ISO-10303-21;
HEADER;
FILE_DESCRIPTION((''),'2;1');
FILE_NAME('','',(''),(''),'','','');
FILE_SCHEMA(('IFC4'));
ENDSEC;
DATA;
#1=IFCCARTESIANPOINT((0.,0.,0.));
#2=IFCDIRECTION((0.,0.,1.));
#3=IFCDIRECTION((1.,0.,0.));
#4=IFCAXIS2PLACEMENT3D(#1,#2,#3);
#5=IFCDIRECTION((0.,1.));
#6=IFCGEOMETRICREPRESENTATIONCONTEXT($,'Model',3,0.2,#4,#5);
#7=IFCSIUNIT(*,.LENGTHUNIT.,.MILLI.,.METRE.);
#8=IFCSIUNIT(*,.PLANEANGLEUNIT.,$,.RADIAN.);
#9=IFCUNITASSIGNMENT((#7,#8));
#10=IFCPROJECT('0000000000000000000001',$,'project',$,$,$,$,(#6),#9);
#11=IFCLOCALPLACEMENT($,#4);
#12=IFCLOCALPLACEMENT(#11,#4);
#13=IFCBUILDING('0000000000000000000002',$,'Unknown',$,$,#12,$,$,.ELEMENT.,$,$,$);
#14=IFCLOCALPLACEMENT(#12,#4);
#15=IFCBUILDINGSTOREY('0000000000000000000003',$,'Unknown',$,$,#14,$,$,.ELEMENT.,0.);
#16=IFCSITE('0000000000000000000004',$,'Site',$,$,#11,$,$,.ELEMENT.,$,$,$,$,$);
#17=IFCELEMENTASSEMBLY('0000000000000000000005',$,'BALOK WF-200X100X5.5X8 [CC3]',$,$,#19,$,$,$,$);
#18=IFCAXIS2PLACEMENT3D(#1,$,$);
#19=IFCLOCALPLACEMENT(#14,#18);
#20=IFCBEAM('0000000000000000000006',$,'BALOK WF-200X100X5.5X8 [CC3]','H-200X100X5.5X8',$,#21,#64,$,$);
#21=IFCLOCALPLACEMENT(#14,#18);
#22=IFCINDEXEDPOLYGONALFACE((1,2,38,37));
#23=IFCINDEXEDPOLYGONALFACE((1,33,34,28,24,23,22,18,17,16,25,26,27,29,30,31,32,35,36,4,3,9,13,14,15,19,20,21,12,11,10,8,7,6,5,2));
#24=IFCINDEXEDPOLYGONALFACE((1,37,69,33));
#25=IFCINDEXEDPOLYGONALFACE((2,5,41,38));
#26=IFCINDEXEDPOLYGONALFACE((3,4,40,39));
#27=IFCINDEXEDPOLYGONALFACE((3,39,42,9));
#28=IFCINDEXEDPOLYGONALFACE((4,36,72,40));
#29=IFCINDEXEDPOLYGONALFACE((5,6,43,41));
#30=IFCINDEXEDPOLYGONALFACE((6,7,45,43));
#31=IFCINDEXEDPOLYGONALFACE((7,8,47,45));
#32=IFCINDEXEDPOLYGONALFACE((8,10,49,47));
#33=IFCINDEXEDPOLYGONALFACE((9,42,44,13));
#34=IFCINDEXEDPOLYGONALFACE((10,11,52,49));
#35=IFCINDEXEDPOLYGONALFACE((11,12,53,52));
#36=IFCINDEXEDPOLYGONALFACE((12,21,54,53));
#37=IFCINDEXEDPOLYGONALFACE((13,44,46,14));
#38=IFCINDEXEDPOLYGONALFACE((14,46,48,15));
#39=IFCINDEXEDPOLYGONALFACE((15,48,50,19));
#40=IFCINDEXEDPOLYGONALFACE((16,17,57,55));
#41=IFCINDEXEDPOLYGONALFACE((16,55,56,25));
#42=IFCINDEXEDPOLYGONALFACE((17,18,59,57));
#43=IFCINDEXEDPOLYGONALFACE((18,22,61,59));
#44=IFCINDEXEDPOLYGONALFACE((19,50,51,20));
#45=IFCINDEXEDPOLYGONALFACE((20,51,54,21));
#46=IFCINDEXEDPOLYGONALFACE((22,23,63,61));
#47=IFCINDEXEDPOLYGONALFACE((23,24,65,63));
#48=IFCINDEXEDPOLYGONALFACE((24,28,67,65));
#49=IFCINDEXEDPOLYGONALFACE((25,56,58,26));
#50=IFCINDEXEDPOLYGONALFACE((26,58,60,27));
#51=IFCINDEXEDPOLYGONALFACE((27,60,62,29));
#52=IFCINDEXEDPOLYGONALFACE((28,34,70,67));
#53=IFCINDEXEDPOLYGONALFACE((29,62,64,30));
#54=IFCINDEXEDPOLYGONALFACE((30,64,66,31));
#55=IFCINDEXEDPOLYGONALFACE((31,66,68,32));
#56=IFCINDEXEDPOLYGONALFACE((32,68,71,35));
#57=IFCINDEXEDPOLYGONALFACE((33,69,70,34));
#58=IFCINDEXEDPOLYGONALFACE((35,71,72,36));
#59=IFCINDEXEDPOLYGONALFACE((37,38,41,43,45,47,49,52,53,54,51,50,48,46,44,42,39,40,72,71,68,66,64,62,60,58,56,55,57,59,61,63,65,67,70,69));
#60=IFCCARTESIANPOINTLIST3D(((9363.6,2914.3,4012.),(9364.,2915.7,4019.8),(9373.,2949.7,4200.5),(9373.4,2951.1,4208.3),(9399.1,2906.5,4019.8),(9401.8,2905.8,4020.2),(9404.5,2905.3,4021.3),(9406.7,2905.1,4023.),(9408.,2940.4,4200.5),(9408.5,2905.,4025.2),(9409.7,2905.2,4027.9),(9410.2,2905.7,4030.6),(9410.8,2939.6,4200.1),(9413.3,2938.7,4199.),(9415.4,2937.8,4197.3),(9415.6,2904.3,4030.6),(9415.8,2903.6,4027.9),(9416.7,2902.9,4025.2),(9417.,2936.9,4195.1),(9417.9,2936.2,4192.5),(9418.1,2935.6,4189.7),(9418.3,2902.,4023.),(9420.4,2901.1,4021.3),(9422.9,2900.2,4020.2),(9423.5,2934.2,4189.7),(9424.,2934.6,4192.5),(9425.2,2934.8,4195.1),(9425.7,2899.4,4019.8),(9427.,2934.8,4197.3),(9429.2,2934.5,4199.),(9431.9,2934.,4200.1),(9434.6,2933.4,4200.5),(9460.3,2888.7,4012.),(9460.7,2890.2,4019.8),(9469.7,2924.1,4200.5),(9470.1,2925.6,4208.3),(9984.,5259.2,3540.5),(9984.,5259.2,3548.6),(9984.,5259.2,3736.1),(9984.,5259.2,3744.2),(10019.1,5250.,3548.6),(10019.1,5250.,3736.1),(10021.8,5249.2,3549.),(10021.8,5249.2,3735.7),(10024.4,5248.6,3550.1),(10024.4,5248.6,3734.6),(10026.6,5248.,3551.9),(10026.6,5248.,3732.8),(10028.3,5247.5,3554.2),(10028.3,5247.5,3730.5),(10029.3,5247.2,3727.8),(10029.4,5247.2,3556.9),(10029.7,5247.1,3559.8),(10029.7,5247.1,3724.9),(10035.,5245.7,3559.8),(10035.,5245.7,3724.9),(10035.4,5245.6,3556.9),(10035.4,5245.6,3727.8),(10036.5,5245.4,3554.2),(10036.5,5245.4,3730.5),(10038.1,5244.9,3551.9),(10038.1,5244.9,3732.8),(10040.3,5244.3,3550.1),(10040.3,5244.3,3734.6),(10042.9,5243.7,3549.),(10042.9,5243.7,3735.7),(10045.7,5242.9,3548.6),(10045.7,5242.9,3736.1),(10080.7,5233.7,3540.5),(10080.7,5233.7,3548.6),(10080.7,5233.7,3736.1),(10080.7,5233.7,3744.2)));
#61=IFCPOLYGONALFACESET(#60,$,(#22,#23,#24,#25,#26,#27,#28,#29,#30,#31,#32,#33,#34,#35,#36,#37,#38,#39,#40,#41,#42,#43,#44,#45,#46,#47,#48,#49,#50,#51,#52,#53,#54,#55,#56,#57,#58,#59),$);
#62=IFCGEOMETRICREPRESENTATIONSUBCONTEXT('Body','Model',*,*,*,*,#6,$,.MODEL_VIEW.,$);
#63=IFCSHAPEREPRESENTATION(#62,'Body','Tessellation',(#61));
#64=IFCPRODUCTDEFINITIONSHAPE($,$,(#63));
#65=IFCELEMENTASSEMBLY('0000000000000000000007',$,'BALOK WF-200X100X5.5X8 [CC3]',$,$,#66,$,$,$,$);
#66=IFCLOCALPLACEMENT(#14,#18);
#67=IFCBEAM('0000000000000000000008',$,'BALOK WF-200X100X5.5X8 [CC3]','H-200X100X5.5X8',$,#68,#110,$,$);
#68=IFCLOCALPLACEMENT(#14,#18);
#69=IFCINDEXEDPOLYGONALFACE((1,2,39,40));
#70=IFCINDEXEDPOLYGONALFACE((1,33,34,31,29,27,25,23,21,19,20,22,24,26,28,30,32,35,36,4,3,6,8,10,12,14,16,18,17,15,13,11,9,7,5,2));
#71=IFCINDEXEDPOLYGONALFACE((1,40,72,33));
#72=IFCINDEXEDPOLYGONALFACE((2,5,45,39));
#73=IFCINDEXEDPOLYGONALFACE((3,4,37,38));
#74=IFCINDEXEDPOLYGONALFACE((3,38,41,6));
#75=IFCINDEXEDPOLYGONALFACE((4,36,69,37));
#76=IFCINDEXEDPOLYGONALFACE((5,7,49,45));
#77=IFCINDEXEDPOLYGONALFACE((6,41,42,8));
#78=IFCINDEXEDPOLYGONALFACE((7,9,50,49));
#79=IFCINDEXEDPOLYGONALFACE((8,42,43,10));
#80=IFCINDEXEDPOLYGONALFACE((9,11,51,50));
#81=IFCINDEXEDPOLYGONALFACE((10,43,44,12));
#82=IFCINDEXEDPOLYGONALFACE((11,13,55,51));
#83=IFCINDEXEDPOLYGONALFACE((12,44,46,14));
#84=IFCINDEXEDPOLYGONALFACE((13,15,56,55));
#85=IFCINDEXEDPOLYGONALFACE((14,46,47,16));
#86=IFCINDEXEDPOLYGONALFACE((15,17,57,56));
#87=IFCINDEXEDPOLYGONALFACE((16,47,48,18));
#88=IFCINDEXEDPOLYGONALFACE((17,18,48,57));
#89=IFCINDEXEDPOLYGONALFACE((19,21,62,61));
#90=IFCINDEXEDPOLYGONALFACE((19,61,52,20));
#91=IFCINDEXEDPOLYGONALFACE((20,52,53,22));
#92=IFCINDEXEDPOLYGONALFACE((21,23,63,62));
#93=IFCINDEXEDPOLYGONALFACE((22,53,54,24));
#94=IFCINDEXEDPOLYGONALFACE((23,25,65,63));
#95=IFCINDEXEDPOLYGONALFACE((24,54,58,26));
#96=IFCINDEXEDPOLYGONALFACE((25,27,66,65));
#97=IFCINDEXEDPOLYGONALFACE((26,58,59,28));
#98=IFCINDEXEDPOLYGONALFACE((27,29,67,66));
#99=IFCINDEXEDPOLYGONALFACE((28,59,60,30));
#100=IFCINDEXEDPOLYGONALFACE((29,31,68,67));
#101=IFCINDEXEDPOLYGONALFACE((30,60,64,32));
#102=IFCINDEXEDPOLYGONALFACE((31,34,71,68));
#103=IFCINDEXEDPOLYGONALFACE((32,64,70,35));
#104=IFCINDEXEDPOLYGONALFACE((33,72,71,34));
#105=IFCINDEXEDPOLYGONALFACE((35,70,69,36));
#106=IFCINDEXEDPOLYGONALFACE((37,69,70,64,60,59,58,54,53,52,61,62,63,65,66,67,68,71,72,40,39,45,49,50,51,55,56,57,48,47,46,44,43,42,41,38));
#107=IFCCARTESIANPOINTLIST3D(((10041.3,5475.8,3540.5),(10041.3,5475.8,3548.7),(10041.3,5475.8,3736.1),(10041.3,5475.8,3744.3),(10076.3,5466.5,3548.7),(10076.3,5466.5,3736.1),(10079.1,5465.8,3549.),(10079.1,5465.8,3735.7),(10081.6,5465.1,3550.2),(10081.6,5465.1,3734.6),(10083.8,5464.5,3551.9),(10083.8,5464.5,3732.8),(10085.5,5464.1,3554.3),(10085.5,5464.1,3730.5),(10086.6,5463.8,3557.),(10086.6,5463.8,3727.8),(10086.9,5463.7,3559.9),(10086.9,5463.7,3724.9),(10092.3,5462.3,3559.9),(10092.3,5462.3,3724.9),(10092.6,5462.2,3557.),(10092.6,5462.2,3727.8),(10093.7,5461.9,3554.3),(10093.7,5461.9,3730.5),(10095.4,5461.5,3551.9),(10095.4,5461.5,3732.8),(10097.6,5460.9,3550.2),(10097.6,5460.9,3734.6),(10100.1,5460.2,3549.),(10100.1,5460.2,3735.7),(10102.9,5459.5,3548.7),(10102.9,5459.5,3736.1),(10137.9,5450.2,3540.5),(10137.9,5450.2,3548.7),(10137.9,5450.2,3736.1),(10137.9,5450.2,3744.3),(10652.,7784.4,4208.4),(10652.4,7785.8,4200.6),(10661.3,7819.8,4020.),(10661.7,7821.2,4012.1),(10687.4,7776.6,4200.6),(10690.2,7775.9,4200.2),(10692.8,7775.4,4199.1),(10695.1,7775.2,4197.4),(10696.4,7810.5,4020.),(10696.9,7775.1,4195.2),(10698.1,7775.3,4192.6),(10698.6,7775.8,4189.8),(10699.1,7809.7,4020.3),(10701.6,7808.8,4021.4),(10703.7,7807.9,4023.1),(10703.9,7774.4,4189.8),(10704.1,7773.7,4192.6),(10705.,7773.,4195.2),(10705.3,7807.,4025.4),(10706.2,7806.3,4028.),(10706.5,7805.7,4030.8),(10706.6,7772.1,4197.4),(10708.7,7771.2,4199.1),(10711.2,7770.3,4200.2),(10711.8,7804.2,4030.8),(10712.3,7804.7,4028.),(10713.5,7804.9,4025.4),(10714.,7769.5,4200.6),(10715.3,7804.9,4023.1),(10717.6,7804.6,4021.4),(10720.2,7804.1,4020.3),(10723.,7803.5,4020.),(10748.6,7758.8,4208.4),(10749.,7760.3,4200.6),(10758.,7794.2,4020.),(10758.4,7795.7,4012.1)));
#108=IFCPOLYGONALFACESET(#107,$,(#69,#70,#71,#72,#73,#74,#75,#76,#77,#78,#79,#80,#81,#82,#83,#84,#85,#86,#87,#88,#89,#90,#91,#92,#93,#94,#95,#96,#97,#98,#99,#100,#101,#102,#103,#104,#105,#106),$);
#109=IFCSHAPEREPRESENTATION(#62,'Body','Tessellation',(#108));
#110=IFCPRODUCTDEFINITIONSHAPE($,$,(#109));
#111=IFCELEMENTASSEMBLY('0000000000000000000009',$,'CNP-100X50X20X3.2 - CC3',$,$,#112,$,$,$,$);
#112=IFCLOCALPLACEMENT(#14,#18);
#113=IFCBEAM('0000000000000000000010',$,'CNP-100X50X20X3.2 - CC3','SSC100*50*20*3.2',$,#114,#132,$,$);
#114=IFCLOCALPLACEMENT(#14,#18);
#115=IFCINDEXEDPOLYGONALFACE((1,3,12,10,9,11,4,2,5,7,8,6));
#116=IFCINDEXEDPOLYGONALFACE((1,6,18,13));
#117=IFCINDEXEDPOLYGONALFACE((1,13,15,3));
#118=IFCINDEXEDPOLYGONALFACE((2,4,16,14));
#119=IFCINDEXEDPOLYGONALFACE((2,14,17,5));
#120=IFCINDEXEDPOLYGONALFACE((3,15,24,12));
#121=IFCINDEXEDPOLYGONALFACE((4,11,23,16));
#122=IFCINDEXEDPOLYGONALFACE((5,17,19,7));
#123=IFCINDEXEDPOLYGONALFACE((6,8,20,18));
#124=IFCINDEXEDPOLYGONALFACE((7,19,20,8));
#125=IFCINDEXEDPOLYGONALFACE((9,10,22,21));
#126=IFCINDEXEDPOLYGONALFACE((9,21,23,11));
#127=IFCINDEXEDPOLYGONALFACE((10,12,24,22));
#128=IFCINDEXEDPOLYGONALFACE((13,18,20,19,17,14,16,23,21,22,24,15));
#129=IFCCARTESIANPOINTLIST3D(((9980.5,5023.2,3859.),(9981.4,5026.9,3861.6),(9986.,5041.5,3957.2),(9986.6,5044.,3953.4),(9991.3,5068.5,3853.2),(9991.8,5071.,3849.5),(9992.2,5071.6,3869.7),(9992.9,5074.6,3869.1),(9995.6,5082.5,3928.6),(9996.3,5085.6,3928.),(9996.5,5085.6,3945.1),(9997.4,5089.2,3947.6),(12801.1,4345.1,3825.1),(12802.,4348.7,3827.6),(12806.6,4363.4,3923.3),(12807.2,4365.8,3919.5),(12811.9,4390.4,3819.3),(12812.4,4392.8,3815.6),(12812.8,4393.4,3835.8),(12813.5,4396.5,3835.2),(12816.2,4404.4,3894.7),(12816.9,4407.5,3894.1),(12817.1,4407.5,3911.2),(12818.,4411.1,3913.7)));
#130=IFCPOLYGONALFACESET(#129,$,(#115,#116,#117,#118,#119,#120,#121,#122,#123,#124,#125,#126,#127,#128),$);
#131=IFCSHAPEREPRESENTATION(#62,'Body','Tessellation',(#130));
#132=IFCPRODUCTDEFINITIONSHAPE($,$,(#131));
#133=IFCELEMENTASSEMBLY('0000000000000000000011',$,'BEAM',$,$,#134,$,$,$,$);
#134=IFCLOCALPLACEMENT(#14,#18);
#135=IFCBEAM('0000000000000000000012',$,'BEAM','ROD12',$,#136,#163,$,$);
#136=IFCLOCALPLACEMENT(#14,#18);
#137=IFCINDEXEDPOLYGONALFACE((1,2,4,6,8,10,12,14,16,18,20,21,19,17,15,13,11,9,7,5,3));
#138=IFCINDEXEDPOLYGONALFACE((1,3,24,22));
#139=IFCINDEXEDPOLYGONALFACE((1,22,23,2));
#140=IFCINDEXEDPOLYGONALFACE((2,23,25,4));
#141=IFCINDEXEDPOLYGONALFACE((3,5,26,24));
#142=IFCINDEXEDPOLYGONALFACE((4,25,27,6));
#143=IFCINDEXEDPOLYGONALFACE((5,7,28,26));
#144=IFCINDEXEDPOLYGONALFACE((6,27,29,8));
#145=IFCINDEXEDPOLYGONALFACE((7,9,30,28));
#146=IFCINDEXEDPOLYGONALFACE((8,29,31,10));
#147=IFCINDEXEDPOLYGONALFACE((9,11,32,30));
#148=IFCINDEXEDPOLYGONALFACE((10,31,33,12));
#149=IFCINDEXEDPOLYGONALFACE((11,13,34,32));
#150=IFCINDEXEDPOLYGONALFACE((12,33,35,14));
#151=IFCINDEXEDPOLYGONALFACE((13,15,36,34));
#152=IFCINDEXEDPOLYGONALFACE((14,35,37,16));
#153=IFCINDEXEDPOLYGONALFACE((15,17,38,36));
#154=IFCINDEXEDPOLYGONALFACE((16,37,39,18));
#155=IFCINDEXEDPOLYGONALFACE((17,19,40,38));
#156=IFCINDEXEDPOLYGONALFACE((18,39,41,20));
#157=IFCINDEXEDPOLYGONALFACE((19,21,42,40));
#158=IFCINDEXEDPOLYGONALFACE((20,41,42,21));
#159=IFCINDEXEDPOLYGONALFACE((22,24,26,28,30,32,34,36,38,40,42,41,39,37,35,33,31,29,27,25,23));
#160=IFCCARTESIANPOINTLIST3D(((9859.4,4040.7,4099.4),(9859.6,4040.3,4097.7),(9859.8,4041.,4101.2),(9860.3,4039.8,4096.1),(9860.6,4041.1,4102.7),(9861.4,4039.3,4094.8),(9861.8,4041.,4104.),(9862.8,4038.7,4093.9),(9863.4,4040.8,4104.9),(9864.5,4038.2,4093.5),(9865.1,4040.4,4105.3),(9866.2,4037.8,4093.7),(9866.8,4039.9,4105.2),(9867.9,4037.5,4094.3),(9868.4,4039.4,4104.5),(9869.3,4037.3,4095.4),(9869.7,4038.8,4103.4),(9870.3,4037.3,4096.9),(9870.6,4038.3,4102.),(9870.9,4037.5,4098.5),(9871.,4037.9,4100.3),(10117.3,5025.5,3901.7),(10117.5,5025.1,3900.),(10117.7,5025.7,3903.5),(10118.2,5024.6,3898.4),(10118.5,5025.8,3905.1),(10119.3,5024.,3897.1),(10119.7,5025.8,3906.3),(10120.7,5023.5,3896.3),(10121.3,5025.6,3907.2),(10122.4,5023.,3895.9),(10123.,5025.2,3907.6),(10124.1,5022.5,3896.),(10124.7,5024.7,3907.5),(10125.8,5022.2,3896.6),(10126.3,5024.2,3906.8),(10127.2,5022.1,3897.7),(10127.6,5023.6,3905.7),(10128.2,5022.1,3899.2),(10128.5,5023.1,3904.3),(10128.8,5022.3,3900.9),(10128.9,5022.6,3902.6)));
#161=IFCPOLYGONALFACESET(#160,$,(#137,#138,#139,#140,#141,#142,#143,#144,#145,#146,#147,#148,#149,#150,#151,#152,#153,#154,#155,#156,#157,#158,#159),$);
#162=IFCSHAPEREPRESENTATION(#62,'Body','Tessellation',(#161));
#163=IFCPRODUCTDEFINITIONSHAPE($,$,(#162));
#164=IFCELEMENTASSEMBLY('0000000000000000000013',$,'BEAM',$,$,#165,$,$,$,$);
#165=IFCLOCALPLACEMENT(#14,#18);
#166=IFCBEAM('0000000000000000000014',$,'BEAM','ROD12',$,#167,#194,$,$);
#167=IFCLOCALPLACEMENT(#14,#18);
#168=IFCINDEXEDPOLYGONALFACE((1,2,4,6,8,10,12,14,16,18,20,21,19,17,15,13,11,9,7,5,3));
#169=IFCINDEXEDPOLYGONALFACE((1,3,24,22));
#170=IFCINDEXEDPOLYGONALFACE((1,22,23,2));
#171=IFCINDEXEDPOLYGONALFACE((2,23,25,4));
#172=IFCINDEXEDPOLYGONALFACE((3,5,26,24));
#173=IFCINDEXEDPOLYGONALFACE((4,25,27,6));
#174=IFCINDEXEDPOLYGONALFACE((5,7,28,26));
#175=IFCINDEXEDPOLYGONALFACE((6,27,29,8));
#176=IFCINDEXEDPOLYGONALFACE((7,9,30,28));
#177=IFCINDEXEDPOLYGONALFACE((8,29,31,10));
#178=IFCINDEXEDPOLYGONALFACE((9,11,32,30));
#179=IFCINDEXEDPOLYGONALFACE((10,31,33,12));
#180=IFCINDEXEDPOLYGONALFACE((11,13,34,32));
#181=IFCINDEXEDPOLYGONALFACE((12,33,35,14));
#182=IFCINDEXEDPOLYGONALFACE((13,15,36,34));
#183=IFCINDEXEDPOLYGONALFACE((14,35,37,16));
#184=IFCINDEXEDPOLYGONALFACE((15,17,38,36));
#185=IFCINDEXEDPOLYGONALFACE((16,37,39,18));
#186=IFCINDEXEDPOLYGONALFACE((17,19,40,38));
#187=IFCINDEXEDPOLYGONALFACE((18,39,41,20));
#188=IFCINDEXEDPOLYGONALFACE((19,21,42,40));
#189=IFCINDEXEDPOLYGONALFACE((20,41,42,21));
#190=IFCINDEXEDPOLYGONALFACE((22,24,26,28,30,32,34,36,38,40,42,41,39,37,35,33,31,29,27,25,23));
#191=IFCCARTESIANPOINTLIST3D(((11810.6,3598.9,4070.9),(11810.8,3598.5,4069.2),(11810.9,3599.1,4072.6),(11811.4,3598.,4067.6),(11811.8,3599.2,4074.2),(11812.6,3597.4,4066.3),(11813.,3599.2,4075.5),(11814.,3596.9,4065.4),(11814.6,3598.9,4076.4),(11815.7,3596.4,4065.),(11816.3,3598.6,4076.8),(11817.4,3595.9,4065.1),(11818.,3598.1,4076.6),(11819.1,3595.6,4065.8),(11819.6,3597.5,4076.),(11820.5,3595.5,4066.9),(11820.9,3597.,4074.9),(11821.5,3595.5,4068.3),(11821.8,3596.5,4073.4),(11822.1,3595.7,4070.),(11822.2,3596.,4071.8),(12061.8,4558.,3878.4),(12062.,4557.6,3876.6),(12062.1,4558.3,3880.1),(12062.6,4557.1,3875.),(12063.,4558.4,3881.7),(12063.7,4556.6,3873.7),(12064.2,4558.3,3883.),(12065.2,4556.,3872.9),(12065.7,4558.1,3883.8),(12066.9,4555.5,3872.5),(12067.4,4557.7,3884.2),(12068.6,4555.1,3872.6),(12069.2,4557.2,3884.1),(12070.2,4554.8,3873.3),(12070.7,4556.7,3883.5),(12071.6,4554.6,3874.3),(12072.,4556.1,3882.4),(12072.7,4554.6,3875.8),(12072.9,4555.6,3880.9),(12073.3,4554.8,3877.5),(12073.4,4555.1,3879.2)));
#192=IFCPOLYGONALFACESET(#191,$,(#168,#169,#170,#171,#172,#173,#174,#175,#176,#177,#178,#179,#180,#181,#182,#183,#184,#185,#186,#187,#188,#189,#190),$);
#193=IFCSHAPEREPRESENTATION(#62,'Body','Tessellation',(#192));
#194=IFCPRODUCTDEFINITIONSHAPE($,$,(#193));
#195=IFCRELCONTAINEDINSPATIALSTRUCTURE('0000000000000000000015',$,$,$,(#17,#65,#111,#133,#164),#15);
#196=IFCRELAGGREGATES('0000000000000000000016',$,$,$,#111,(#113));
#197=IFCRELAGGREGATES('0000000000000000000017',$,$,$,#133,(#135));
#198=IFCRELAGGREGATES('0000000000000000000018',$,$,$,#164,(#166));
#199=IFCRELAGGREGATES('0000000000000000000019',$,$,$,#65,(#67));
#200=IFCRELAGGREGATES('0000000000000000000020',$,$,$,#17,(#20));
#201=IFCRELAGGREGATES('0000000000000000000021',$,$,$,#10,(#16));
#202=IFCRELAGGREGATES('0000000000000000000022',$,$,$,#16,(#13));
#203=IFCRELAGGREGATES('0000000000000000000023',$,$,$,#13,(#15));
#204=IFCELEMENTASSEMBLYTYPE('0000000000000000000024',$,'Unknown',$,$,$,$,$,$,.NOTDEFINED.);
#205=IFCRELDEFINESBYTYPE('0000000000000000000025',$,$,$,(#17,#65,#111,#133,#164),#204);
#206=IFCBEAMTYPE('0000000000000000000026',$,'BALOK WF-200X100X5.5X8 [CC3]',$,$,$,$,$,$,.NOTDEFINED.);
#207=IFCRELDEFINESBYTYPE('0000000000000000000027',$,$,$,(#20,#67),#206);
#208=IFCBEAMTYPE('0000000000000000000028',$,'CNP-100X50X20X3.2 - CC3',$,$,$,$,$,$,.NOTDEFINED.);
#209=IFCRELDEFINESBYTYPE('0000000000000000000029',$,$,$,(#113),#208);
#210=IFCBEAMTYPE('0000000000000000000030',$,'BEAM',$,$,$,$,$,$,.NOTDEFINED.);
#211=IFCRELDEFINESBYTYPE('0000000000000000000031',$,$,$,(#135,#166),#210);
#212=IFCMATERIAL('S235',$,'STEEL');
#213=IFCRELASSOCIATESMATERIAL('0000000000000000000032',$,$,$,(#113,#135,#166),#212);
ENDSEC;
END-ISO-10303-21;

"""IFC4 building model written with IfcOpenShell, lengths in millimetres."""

from ifc_helpers import new_model, si_unit, direction, frame, origin_with_axes, origin_2d_with_axis, place, context, subcontext, project, spatial, circle, i_section, c_section, extrude, clip, halfspace, material, material_profile, profile_set, profile_usage, type_object, element, aggregate, save


model = new_model("IFC4")

# Units and contexts
model_context = context("Model", 3, precision=0.2, world=origin_with_axes(), true_north=direction((0.0, 1.0)))
body_context = subcontext(model_context, "Body", "Model", "MODEL_VIEW")
ifc_project = project(units=[si_unit("LENGTHUNIT", "METRE", prefix="MILLI"), si_unit("PLANEANGLEUNIT", "RADIAN")], contexts=[model_context])

# Site, building, storey
site_placement = place(None, origin_with_axes())
site = spatial("IfcSite", under=ifc_project, at=site_placement, Name="Site", CompositionType="ELEMENT")
building_placement = place(site_placement, origin_with_axes())
building = spatial("IfcBuilding", under=site, at=building_placement, Name="Unknown", CompositionType="ELEMENT")
storey_placement = place(building_placement, origin_with_axes())
storey = spatial("IfcBuildingStorey", under=building, at=storey_placement, Name="Unknown", CompositionType="ELEMENT", Elevation=0.0)

# Element assemblies, beams
element_assembly_type = type_object("IfcElementAssemblyType", Name="Unknown", PredefinedType="NOTDEFINED")
assembly_1_placement = place(storey_placement, frame((10038.2, 5268.6, 3637.9), z_axis=(-0.966739, 0.255765, -0.000005), x_axis=(-0.251067, -0.948977, 0.190809)))
assembly_1 = element("IfcElementAssembly", 1, at=assembly_1_placement, inside=storey, type_object=element_assembly_type, Name="BALOK WF-200X100X5.5X8 [CC3]")
beam_type_1 = type_object("IfcBeamType", Name="BALOK WF-200X100X5.5X8 [CC3]", PredefinedType="NOTDEFINED")
beam_1_placement = place(assembly_1_placement, origin_with_axes())
beam_1 = element("IfcBeam", 2, at=beam_1_placement, type_object=beam_type_1, Name="BALOK WF-200X100X5.5X8 [CC3]", Description="H-200X100X5.5X8", context=body_context, shape_type="Clipping", body=[
    clip(extrude(i_section(OverallWidth=100.0, OverallDepth=200.0, WebThickness=5.5, FlangeThickness=8.0, FilletRadius=11.0, FlangeEdgeRadius=0.0, FlangeSlope=0.0, at=origin_2d_with_axis()), frame((0.0, 0.0, 0.0), z_axis=(-1.0, 0.0, 0.0), x_axis=(0.0, 0.0, 1.0)), (0.0, 0.0, -1.0), 2475.0), halfspace(frame((3.9, -100.0, -50.0), z_axis=(-0.981627, 0.190809, 0.000262), x_axis=(0.000267, 0.0, 1.0)), False)),
])
assembly_2_placement = place(storey_placement, frame((10083.9, 5441.3, 3638.0), z_axis=(0.966746, -0.255739, 0.0), x_axis=(0.25104, 0.948984, 0.190809)))
assembly_2 = element("IfcElementAssembly", 3, at=assembly_2_placement, inside=storey, type_object=element_assembly_type, Name="BALOK WF-200X100X5.5X8 [CC3]")
beam_2_placement = place(assembly_2_placement, origin_with_axes())
beam_2 = element("IfcBeam", 4, at=beam_2_placement, type_object=beam_type_1, Name="BALOK WF-200X100X5.5X8 [CC3]", Description="H-200X100X5.5X8", context=body_context, shape_type="Clipping", body=[
    clip(extrude(i_section(OverallWidth=100.0, OverallDepth=200.0, WebThickness=5.5, FlangeThickness=8.0, FilletRadius=11.0, FlangeEdgeRadius=0.0, FlangeSlope=0.0, at=origin_2d_with_axis()), frame((0.0, 0.0, 0.0), z_axis=(-1.0, 0.0, 0.0), x_axis=(0.0, 0.0, 1.0)), (0.0, 0.0, -1.0), 2475.0), halfspace(frame((3.5, -100.0, -50.0), z_axis=(-0.981627, 0.190809, 0.000235), x_axis=(0.000239, 0.0, 1.0)), False)),
])
assembly_3_placement = place(storey_placement, frame((9988.9, 5056.2, 3903.3), z_axis=(0.227294, 0.954953, -0.190796), x_axis=(0.972228, -0.233742, -0.011692)))
assembly_3 = element("IfcElementAssembly", 5, at=assembly_3_placement, inside=storey, type_object=element_assembly_type, Name="CNP-100X50X20X3.2 - CC3")
ifc_material_1 = material(Name="S235", Category="STEEL")
ifc_material_profile_1 = material_profile(ifc_material_1, c_section(Depth=100.0, Width=50.0, WallThickness=3.2, Girth=20.0, at=origin_2d_with_axis()), Name="SSC100*50*20*3.2")
ifc_profile_set_1 = profile_set([ifc_material_profile_1])
ifc_profile_usage_1 = profile_usage(ifc_profile_set_1, cardinal=4)
beam_type_2 = type_object("IfcBeamType", Name="CNP-100X50X20X3.2 - CC3", PredefinedType="NOTDEFINED")
beam_3_placement = place(assembly_3_placement, origin_with_axes())
beam_3 = element("IfcBeam", 6, at=beam_3_placement, type_object=beam_type_2, material=ifc_profile_usage_1, Name="CNP-100X50X20X3.2 - CC3", Description="SSC100*50*20*3.2", context=body_context, shape_type="SolidModel", body=[
    extrude(c_section(Depth=100.0, Width=50.0, WallThickness=3.2, Girth=20.0, at=origin_2d_with_axis()), frame((0.0, 0.0, 0.0), z_axis=(-1.0, 0.0, 0.0), x_axis=(0.0, 0.0, 1.0)), (0.0, 0.0, -1.0), 2901.2),
])
aggregate(assembly_3, [beam_3])
assembly_4_placement = place(storey_placement, frame((10123.1, 5024.0, 3901.7), z_axis=(-0.967378, 0.253339, 0.0), x_axis=(-0.248693, -0.949638, 0.190629)))
assembly_4 = element("IfcElementAssembly", 7, at=assembly_4_placement, inside=storey, type_object=element_assembly_type, Name="BEAM")
ifc_material_profile_2 = material_profile(ifc_material_1, circle(Radius=6.0, at=origin_2d_with_axis()), Name="ROD12")
ifc_profile_set_2 = profile_set([ifc_material_profile_2])
ifc_profile_usage_2 = profile_usage(ifc_profile_set_2, cardinal=5)
beam_type_3 = type_object("IfcBeamType", Name="BEAM", PredefinedType="NOTDEFINED")
beam_4_placement = place(assembly_4_placement, origin_with_axes())
beam_4 = element("IfcBeam", 8, at=beam_4_placement, type_object=beam_type_3, material=ifc_profile_usage_2, Name="BEAM", Description="ROD12", context=body_context, shape_type="SolidModel", body=[
    extrude(circle(Radius=6.0, at=origin_2d_with_axis()), frame((0.0, 0.0, 0.0), z_axis=(-1.0, 0.0, 0.0), x_axis=(0.0, 0.0, 1.0)), (0.0, 0.0, -1.0), 1037.0),
])
aggregate(assembly_4, [beam_4])
assembly_5_placement = place(storey_placement, frame((12067.6, 4556.5, 3878.4), z_axis=(-0.967378, 0.253339, 0.0), x_axis=(-0.248693, -0.949638, 0.190629)))
assembly_5 = element("IfcElementAssembly", 9, at=assembly_5_placement, inside=storey, type_object=element_assembly_type, Name="BEAM")
beam_5_placement = place(assembly_5_placement, origin_with_axes())
beam_5 = element("IfcBeam", 10, at=beam_5_placement, type_object=beam_type_3, material=ifc_profile_usage_2, Name="BEAM", Description="ROD12", context=body_context, shape_type="SolidModel", body=[
    extrude(circle(Radius=6.0, at=origin_2d_with_axis()), frame((0.0, 0.0, 0.0), z_axis=(-1.0, 0.0, 0.0), x_axis=(0.0, 0.0, 1.0)), (0.0, 0.0, -1.0), 1010.0),
])
aggregate(assembly_5, [beam_5])

aggregate(assembly_2, [beam_2])

aggregate(assembly_1, [beam_1])

save(model, "model.ifc")
